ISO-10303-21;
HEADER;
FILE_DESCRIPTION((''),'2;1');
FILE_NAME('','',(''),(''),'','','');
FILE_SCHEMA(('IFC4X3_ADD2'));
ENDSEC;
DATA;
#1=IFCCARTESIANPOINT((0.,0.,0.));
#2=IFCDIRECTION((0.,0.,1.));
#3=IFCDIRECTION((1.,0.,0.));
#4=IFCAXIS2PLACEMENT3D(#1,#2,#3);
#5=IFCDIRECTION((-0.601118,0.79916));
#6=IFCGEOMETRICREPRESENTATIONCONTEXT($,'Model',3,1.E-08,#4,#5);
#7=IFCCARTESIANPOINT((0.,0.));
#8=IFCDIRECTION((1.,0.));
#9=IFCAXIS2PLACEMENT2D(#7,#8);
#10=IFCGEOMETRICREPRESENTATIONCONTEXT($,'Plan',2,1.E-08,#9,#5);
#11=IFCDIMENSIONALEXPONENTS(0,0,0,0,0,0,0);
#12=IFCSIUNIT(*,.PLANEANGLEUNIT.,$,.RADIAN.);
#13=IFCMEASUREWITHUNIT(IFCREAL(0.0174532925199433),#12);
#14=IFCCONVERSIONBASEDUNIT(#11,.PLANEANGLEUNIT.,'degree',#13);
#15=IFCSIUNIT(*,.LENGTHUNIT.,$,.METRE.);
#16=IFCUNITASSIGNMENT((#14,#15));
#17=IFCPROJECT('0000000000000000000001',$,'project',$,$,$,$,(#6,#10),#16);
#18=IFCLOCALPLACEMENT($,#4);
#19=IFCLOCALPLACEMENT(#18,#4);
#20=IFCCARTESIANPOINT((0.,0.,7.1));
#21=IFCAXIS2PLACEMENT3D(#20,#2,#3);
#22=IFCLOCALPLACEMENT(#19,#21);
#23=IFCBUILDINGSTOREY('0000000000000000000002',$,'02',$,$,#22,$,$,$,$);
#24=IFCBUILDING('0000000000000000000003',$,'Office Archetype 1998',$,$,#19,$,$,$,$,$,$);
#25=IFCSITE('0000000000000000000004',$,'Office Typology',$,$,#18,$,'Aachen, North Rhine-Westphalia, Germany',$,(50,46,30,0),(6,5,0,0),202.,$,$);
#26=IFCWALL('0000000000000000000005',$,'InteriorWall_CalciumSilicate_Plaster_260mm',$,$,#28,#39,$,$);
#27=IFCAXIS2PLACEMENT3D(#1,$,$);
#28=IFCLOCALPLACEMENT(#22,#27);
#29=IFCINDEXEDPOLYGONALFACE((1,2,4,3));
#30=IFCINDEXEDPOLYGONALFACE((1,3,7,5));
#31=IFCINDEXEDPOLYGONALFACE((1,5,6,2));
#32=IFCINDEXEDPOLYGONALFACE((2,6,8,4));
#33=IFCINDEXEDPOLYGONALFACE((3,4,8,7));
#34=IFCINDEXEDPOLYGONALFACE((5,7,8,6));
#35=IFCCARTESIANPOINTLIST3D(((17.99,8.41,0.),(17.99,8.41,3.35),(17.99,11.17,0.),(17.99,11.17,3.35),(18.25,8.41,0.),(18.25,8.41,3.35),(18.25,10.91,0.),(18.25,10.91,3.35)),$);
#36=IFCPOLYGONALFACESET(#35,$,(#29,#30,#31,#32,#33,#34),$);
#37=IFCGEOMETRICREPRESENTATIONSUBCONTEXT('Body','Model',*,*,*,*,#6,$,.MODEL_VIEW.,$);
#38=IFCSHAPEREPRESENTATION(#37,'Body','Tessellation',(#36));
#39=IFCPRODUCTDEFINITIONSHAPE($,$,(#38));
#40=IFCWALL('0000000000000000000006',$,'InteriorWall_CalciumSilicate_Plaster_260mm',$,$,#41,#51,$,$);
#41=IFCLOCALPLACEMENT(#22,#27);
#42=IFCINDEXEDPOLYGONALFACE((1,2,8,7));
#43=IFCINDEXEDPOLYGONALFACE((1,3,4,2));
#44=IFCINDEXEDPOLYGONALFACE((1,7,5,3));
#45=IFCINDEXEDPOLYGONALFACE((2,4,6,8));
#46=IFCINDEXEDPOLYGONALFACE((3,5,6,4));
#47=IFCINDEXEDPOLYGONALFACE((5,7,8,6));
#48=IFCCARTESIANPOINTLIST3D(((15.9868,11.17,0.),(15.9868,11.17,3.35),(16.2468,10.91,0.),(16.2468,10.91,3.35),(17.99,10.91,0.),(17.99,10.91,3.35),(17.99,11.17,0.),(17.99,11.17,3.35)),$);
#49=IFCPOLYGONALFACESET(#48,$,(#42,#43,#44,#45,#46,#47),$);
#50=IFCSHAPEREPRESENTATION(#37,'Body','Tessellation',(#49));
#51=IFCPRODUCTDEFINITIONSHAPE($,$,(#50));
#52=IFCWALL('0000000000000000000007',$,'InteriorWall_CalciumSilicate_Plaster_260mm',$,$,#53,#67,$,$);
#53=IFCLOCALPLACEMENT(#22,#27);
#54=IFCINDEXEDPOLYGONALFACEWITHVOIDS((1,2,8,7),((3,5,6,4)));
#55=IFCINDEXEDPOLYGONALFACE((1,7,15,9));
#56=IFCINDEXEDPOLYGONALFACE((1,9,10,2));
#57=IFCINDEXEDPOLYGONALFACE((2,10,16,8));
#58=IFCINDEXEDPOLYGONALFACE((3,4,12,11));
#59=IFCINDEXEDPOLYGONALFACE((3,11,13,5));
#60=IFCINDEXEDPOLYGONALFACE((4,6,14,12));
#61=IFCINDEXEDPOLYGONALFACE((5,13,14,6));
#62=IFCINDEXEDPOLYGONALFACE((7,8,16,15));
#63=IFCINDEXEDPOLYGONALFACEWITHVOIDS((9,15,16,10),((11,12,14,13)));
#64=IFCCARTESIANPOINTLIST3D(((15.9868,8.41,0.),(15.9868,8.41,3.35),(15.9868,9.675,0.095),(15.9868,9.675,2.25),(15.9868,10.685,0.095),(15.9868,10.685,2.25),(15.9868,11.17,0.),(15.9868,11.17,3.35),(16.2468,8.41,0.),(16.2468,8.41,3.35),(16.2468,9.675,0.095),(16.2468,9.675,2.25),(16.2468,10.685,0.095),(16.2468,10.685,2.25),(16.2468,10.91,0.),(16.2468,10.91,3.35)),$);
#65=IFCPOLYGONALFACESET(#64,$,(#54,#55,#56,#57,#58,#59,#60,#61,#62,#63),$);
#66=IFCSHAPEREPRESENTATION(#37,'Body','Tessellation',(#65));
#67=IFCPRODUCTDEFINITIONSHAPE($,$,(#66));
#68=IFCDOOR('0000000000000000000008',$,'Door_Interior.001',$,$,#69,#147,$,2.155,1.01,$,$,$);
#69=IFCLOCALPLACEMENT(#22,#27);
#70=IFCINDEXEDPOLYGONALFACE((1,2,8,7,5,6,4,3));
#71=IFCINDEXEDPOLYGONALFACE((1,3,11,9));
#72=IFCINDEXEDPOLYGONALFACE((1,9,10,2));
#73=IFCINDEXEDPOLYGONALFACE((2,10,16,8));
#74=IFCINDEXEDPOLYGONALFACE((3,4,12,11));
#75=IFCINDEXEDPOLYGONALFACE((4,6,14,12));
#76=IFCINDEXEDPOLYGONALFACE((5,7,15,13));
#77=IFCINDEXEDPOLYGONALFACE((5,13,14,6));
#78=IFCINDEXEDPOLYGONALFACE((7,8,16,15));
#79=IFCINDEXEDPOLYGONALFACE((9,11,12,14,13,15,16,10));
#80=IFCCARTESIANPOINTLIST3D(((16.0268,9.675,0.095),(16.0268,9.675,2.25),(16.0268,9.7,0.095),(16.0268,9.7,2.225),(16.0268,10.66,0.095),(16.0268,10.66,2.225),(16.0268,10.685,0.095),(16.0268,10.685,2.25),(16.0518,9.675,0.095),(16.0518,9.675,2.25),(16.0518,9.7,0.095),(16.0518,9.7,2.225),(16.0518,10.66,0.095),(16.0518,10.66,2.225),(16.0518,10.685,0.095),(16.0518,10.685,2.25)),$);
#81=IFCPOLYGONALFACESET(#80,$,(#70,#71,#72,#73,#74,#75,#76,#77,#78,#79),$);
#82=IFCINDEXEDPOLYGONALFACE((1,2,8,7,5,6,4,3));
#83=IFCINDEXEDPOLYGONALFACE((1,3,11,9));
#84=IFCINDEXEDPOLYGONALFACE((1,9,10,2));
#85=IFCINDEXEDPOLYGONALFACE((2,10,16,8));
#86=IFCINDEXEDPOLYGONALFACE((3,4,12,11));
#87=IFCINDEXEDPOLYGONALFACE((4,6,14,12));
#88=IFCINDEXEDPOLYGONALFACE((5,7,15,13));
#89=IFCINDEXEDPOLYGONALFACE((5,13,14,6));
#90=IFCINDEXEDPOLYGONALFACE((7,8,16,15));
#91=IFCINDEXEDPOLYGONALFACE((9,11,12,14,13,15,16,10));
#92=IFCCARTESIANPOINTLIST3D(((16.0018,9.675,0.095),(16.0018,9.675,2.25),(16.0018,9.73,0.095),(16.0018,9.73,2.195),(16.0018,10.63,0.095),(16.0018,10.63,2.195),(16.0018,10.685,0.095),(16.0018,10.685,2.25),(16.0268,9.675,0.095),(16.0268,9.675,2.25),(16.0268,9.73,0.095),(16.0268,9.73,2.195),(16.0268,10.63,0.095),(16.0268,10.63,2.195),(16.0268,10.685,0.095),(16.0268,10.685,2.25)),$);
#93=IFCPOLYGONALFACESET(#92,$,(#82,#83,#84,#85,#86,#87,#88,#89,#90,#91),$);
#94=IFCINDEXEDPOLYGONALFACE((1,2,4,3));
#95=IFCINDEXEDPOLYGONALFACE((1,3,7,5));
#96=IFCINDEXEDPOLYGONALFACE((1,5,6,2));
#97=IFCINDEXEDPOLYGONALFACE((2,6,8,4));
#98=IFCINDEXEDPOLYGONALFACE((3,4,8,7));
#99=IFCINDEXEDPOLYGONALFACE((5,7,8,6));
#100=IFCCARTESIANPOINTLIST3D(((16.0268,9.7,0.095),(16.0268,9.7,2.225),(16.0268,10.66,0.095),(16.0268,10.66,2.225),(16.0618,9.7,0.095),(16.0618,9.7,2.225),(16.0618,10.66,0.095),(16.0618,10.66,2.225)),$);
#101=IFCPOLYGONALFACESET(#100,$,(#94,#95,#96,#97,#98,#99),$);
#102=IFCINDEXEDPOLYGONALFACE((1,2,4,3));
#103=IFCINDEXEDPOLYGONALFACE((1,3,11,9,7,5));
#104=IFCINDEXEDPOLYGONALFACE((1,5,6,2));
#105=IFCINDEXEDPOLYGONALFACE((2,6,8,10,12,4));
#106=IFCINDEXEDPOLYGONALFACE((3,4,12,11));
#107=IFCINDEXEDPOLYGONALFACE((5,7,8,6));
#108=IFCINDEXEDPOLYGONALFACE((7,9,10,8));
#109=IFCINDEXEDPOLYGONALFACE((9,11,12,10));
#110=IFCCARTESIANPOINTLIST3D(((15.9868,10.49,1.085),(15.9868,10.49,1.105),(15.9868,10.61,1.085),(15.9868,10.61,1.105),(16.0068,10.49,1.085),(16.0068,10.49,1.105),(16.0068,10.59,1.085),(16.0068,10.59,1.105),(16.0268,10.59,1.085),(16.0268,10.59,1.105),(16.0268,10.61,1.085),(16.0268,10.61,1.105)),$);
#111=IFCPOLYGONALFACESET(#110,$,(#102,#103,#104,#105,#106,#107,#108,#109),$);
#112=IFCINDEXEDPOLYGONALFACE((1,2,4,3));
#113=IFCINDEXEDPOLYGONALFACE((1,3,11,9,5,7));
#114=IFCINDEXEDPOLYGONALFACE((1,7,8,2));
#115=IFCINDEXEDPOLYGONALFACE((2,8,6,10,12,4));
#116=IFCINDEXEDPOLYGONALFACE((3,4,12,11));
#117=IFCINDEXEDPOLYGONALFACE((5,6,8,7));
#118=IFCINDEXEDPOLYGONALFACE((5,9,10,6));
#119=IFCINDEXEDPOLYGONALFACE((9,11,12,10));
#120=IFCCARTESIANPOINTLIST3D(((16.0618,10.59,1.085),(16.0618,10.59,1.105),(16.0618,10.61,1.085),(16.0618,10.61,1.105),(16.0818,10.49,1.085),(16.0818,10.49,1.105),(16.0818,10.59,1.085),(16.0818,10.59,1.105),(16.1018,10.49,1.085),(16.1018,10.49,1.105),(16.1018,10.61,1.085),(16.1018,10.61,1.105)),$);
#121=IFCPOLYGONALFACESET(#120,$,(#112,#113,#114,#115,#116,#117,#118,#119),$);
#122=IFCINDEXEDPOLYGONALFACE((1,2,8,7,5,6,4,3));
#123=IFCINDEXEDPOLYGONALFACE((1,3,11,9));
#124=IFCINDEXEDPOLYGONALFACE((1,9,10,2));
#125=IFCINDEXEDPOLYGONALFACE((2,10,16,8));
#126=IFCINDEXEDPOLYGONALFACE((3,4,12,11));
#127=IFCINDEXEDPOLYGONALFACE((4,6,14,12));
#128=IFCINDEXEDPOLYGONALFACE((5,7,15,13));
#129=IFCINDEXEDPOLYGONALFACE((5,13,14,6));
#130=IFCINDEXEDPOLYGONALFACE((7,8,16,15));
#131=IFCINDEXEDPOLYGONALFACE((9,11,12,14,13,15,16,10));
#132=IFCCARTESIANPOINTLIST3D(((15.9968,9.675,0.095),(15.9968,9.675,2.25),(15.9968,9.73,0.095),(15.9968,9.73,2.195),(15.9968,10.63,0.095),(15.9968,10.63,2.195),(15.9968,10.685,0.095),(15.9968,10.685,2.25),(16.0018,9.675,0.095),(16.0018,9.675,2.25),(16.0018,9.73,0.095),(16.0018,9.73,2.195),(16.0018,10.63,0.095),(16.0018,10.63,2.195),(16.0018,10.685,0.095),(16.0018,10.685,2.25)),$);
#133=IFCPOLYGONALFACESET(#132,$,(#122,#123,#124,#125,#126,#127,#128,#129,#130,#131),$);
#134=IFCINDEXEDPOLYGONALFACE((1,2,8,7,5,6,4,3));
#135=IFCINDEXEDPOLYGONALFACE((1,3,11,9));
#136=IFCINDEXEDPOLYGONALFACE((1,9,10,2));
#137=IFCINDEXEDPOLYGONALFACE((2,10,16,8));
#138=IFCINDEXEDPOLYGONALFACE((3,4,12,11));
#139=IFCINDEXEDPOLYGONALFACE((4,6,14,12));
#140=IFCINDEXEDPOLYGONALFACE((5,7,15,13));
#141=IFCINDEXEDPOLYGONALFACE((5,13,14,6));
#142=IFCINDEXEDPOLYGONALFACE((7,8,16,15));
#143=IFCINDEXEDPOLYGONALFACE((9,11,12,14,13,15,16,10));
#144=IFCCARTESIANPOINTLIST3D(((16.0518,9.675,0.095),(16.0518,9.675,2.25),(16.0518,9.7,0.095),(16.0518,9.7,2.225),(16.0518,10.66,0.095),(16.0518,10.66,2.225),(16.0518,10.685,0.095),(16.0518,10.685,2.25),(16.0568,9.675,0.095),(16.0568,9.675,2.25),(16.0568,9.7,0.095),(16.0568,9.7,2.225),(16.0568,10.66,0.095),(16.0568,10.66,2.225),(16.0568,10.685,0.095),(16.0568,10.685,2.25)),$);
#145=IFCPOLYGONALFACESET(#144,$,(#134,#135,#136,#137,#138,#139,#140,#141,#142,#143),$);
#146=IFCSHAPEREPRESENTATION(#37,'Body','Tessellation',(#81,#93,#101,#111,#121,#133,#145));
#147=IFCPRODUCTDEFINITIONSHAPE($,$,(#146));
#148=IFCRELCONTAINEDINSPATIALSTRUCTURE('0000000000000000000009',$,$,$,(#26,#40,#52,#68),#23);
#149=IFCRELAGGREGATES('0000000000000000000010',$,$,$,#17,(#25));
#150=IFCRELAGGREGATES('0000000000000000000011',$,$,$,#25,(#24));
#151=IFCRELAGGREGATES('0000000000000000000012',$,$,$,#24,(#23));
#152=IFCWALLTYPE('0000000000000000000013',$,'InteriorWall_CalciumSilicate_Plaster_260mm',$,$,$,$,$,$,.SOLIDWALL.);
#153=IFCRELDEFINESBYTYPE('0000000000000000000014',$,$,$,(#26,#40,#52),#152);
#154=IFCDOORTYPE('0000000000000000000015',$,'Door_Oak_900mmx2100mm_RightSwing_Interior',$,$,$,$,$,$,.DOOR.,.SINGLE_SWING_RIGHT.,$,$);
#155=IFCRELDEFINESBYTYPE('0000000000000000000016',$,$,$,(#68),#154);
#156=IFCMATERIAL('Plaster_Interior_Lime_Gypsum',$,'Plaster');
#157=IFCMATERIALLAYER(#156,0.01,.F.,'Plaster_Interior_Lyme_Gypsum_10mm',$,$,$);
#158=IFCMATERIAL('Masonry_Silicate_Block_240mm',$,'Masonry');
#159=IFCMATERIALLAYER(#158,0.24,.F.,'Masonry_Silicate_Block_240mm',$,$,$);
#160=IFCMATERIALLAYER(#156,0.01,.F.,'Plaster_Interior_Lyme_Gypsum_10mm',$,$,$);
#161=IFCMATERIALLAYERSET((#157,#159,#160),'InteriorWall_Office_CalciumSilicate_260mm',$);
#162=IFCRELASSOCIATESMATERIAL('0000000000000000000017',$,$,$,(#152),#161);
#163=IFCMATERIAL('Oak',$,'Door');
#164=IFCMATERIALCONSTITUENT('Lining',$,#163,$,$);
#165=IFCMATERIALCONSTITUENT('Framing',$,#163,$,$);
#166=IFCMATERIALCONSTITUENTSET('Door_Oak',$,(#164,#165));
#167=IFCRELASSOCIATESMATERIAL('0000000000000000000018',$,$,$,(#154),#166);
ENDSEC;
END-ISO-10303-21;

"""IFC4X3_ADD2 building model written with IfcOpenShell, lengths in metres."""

from ifc_helpers import new_model, entity, si_unit, converted_unit, direction, frame, origin_with_axes, origin_2d_with_axis, place, context, subcontext, project, spatial, line, indexed_curve, outline, extrude, source, transform, mapped, material, layer, layer_set, constituent, constituent_set, type_object, type_shapes, element, fill, save


model = new_model("IFC4X3_ADD2")

# Units and contexts
model_context = context("Model", 3, precision=1e-08, world=origin_with_axes(), true_north=direction((-0.601118, 0.79916)))
plan_context = context("Plan", 2, precision=1e-08, world=origin_2d_with_axis(), true_north=direction((-0.601118, 0.79916)))
body_context = subcontext(model_context, "Body", "Model", "MODEL_VIEW")
ifc_project = project(units=[converted_unit("PLANEANGLEUNIT", "degree", entity("IfcReal", 0.0174532925199433), si_unit("PLANEANGLEUNIT", "RADIAN"), dimensions=[0, 0, 0, 0, 0, 0, 0]), si_unit("LENGTHUNIT", "METRE")], contexts=[model_context, plan_context])

# Site, building, storey
site_placement = place(None, origin_with_axes())
site = spatial("IfcSite", under=ifc_project, at=site_placement, Name="Office Typology", LongName="Aachen, North Rhine-Westphalia, Germany", RefLatitude=(50, 46, 30, 0), RefLongitude=(6, 5, 0, 0), RefElevation=202.0)
building_placement = place(site_placement, origin_with_axes())
building = spatial("IfcBuilding", under=site, at=building_placement, Name="Office Archetype 1998")
storey_placement = place(building_placement, frame((0.0, 0.0, 7.1), z_axis=(0.0, 0.0, 1.0), x_axis=(1.0, 0.0, 0.0)))
storey = spatial("IfcBuildingStorey", under=building, at=storey_placement, Name="02")

# Walls
ifc_material_1 = material(Name="Plaster_Interior_Lime_Gypsum", Category="Plaster")
ifc_layer_1 = layer(ifc_material_1, 0.01, ventilated=False, Name="Plaster_Interior_Lyme_Gypsum_10mm")
ifc_material_2 = material(Name="Masonry_Silicate_Block_240mm", Category="Masonry")
ifc_layer_2 = layer(ifc_material_2, 0.24, ventilated=False, Name="Masonry_Silicate_Block_240mm")
ifc_layer_3 = layer(ifc_material_1, 0.01, ventilated=False, Name="Plaster_Interior_Lyme_Gypsum_10mm")
ifc_layer_set_1 = layer_set([ifc_layer_1, ifc_layer_2, ifc_layer_3], Name="InteriorWall_Office_CalciumSilicate_260mm")
wall_type_1 = type_object("IfcWallType", Name="InteriorWall_CalciumSilicate_Plaster_260mm", PredefinedType="SOLIDWALL", material=ifc_layer_set_1)
wall_1_placement = place(storey_placement, frame((17.99, 11.17, 0.0), z_axis=(0.0, 0.0, 1.0), x_axis=(0.0, -1.0, 0.0)))
element("IfcWall", 1, at=wall_1_placement, inside=storey, type_object=wall_type_1, Name="InteriorWall_CalciumSilicate_Plaster_260mm", context=body_context, shape_type="SweptSolid", body=[
    extrude(outline(indexed_curve([(0.0, 0.0), (0.26, 0.26), (2.76, 0.26), (2.76, 0.0)], segments=[line(1, 2, 3, 4, 1)])), origin_with_axes(), (0.0, 0.0, 1.0), 3.35),
])
wall_2_placement = place(storey_placement, frame((17.99, 11.17, 0.0), z_axis=(0.0, 0.0, 1.0), x_axis=(-1.0, 0.0, 0.0)))
element("IfcWall", 2, at=wall_2_placement, inside=storey, type_object=wall_type_1, Name="InteriorWall_CalciumSilicate_Plaster_260mm", context=body_context, shape_type="SweptSolid", body=[
    extrude(outline(indexed_curve([(0.0, 0.0), (0.0, 0.26), (1.7432, 0.26), (2.0032, 0.0)], segments=[line(1, 2, 3, 4, 1)])), origin_with_axes(), (0.0, 0.0, 1.0), 3.35),
])

# Wall, opening, door
wall_3_placement = place(storey_placement, frame((15.9868, 11.17, 0.0), z_axis=(0.0, 0.0, 1.0), x_axis=(0.0, -1.0, 0.0)))
wall_3 = element("IfcWall", 3, at=wall_3_placement, inside=storey, type_object=wall_type_1, Name="InteriorWall_CalciumSilicate_Plaster_260mm", context=body_context, shape_type="SweptSolid", body=[
    extrude(outline(indexed_curve([(0.0, 0.0), (0.26, 0.26), (2.76, 0.26), (2.76, 0.0)], segments=[line(1, 2, 3, 4, 1)])), origin_with_axes(), (0.0, 0.0, 1.0), 3.35),
])
shared_shape_1 = source(origin_with_axes(), body_context, "Body", "SweptSolid", [
    extrude(outline(indexed_curve([(0.0, 2.155), (1.01, 2.155), (1.01, 0.0), (0.0, 0.0), (0.0, 2.155)])), frame((0.0, 0.0, 0.0), z_axis=(0.0, -1.0, 0.0), x_axis=(1.0, 0.0, 0.0)), (0.0, 0.0, -1.0), 0.26),
])
opening_1_placement = place(wall_3_placement, frame((0.485, 0.0, 0.095), z_axis=(0.0, 0.0, 1.0), x_axis=(1.0, 0.0, 0.0)))
opening_1 = element("IfcOpeningElement", 4, at=opening_1_placement, cuts=wall_3, PredefinedType="OPENING", context=body_context, shape_type="MappedRepresentation", body=[
    mapped(shared_shape_1, transform((0.0, 0.0, 0.0), x_axis=(1.0, 0.0, 0.0), y_axis=(0.0, 1.0, 0.0), z_axis=(0.0, 0.0, 1.0), scale=1.0)),
])
ifc_material_3 = material(Name="Oak", Category="Door")
ifc_constituent_1 = constituent(ifc_material_3, Name="Lining")
ifc_constituent_2 = constituent(ifc_material_3, Name="Framing")
ifc_constituent_set_1 = constituent_set(constituents=[ifc_constituent_1, ifc_constituent_2], Name="Door_Oak")
door_type_1 = type_object("IfcDoorType", Name="Door_Oak_900mmx2100mm_RightSwing_Interior", OperationType="SINGLE_SWING_RIGHT", PredefinedType="DOOR", material=ifc_constituent_set_1)
shared_shape_2 = source(origin_with_axes(), body_context, "Body", "SweptSolid", [
    extrude(outline(indexed_curve([(0.0, 0.0), (0.0, 2.155), (1.01, 2.155), (1.01, 0.0), (0.985, 0.0), (0.985, 2.13), (0.025, 2.13), (0.025, 0.0)], segments=[line(1, 2, 3, 4, 5, 6, 7, 8, 1)])), frame((0.0, 0.025, 0.0), z_axis=(0.0, -1.0, 0.0), x_axis=(1.0, 0.0, 0.0)), (0.0, 0.0, -1.0), 0.025),
    extrude(outline(indexed_curve([(0.0, 0.0), (0.0, 2.155), (1.01, 2.155), (1.01, 0.0), (0.955, 0.0), (0.955, 2.1), (0.055, 2.1), (0.055, 0.0)], segments=[line(1, 2, 3, 4, 5, 6, 7, 8, 1)])), frame((0.0, 0.0, 0.0), z_axis=(0.0, -1.0, 0.0), x_axis=(1.0, 0.0, 0.0)), (0.0, 0.0, -1.0), 0.025),
    extrude(outline(indexed_curve([(0.0, 0.0), (0.96, 0.0), (0.96, 0.035), (0.0, 0.035)], segments=[line(1, 2, 3, 4, 1)])), frame((0.025, 0.025, 0.0), z_axis=(0.0, 0.0, 1.0), x_axis=(1.0, 0.0, 0.0)), (0.0, 0.0, 1.0), 2.13),
    extrude(outline(indexed_curve([(0.0, 0.0), (0.0, -0.04), (0.12, -0.04), (0.12, -0.02), (0.02, -0.02), (0.02, 0.0)], segments=[line(1, 2, 3, 4, 5, 6, 1)])), frame((0.075, 0.025, 0.99), z_axis=(0.0, 0.0, 1.0), x_axis=(1.0, 0.0, 0.0)), (0.0, 0.0, 1.0), 0.02),
    extrude(outline(indexed_curve([(0.0, 0.0), (0.0, 0.04), (0.12, 0.04), (0.12, 0.02), (0.02, 0.02), (0.02, 0.0)], segments=[line(1, 2, 3, 4, 5, 6, 1)])), frame((0.075, 0.06, 0.99), z_axis=(0.0, 0.0, 1.0), x_axis=(1.0, 0.0, 0.0)), (0.0, 0.0, 1.0), 0.02),
    extrude(outline(indexed_curve([(0.0, 0.0), (0.0, 2.155), (1.01, 2.155), (1.01, 0.0), (0.955, 0.0), (0.955, 2.1), (0.055, 2.1), (0.055, 0.0)], segments=[line(1, 2, 3, 4, 5, 6, 7, 8, 1)])), frame((0.0, -0.005, 0.0), z_axis=(0.0, -1.0, 0.0), x_axis=(1.0, 0.0, 0.0)), (0.0, 0.0, -1.0), 0.005),
    extrude(outline(indexed_curve([(0.0, 0.0), (0.0, 2.155), (1.01, 2.155), (1.01, 0.0), (0.985, 0.0), (0.985, 2.13), (0.025, 2.13), (0.025, 0.0)], segments=[line(1, 2, 3, 4, 5, 6, 7, 8, 1)])), frame((0.0, 0.05, 0.0), z_axis=(0.0, -1.0, 0.0), x_axis=(1.0, 0.0, 0.0)), (0.0, 0.0, -1.0), 0.005),
])
type_shapes(door_type_1, [shared_shape_2])
door_1_placement = place(opening_1_placement, frame((0.0, 0.015, 0.0), z_axis=(0.0, 0.0, 1.0), x_axis=(1.0, 0.0, 0.0)))
door_1 = element("IfcDoor", 5, at=door_1_placement, inside=storey, type_object=door_type_1, Name="Door_Interior.001", OverallHeight=2.155, OverallWidth=1.01, context=body_context, shape_type="MappedRepresentation", body=[
    mapped(shared_shape_2, transform((0.0, 0.0, 0.0), x_axis=(1.0, 0.0, 0.0), y_axis=(0.0, 1.0, 0.0), z_axis=(0.0, 0.0, 1.0), scale=1.0)),
])
fill(opening_1, door_1)

save(model, "model.ifc")
